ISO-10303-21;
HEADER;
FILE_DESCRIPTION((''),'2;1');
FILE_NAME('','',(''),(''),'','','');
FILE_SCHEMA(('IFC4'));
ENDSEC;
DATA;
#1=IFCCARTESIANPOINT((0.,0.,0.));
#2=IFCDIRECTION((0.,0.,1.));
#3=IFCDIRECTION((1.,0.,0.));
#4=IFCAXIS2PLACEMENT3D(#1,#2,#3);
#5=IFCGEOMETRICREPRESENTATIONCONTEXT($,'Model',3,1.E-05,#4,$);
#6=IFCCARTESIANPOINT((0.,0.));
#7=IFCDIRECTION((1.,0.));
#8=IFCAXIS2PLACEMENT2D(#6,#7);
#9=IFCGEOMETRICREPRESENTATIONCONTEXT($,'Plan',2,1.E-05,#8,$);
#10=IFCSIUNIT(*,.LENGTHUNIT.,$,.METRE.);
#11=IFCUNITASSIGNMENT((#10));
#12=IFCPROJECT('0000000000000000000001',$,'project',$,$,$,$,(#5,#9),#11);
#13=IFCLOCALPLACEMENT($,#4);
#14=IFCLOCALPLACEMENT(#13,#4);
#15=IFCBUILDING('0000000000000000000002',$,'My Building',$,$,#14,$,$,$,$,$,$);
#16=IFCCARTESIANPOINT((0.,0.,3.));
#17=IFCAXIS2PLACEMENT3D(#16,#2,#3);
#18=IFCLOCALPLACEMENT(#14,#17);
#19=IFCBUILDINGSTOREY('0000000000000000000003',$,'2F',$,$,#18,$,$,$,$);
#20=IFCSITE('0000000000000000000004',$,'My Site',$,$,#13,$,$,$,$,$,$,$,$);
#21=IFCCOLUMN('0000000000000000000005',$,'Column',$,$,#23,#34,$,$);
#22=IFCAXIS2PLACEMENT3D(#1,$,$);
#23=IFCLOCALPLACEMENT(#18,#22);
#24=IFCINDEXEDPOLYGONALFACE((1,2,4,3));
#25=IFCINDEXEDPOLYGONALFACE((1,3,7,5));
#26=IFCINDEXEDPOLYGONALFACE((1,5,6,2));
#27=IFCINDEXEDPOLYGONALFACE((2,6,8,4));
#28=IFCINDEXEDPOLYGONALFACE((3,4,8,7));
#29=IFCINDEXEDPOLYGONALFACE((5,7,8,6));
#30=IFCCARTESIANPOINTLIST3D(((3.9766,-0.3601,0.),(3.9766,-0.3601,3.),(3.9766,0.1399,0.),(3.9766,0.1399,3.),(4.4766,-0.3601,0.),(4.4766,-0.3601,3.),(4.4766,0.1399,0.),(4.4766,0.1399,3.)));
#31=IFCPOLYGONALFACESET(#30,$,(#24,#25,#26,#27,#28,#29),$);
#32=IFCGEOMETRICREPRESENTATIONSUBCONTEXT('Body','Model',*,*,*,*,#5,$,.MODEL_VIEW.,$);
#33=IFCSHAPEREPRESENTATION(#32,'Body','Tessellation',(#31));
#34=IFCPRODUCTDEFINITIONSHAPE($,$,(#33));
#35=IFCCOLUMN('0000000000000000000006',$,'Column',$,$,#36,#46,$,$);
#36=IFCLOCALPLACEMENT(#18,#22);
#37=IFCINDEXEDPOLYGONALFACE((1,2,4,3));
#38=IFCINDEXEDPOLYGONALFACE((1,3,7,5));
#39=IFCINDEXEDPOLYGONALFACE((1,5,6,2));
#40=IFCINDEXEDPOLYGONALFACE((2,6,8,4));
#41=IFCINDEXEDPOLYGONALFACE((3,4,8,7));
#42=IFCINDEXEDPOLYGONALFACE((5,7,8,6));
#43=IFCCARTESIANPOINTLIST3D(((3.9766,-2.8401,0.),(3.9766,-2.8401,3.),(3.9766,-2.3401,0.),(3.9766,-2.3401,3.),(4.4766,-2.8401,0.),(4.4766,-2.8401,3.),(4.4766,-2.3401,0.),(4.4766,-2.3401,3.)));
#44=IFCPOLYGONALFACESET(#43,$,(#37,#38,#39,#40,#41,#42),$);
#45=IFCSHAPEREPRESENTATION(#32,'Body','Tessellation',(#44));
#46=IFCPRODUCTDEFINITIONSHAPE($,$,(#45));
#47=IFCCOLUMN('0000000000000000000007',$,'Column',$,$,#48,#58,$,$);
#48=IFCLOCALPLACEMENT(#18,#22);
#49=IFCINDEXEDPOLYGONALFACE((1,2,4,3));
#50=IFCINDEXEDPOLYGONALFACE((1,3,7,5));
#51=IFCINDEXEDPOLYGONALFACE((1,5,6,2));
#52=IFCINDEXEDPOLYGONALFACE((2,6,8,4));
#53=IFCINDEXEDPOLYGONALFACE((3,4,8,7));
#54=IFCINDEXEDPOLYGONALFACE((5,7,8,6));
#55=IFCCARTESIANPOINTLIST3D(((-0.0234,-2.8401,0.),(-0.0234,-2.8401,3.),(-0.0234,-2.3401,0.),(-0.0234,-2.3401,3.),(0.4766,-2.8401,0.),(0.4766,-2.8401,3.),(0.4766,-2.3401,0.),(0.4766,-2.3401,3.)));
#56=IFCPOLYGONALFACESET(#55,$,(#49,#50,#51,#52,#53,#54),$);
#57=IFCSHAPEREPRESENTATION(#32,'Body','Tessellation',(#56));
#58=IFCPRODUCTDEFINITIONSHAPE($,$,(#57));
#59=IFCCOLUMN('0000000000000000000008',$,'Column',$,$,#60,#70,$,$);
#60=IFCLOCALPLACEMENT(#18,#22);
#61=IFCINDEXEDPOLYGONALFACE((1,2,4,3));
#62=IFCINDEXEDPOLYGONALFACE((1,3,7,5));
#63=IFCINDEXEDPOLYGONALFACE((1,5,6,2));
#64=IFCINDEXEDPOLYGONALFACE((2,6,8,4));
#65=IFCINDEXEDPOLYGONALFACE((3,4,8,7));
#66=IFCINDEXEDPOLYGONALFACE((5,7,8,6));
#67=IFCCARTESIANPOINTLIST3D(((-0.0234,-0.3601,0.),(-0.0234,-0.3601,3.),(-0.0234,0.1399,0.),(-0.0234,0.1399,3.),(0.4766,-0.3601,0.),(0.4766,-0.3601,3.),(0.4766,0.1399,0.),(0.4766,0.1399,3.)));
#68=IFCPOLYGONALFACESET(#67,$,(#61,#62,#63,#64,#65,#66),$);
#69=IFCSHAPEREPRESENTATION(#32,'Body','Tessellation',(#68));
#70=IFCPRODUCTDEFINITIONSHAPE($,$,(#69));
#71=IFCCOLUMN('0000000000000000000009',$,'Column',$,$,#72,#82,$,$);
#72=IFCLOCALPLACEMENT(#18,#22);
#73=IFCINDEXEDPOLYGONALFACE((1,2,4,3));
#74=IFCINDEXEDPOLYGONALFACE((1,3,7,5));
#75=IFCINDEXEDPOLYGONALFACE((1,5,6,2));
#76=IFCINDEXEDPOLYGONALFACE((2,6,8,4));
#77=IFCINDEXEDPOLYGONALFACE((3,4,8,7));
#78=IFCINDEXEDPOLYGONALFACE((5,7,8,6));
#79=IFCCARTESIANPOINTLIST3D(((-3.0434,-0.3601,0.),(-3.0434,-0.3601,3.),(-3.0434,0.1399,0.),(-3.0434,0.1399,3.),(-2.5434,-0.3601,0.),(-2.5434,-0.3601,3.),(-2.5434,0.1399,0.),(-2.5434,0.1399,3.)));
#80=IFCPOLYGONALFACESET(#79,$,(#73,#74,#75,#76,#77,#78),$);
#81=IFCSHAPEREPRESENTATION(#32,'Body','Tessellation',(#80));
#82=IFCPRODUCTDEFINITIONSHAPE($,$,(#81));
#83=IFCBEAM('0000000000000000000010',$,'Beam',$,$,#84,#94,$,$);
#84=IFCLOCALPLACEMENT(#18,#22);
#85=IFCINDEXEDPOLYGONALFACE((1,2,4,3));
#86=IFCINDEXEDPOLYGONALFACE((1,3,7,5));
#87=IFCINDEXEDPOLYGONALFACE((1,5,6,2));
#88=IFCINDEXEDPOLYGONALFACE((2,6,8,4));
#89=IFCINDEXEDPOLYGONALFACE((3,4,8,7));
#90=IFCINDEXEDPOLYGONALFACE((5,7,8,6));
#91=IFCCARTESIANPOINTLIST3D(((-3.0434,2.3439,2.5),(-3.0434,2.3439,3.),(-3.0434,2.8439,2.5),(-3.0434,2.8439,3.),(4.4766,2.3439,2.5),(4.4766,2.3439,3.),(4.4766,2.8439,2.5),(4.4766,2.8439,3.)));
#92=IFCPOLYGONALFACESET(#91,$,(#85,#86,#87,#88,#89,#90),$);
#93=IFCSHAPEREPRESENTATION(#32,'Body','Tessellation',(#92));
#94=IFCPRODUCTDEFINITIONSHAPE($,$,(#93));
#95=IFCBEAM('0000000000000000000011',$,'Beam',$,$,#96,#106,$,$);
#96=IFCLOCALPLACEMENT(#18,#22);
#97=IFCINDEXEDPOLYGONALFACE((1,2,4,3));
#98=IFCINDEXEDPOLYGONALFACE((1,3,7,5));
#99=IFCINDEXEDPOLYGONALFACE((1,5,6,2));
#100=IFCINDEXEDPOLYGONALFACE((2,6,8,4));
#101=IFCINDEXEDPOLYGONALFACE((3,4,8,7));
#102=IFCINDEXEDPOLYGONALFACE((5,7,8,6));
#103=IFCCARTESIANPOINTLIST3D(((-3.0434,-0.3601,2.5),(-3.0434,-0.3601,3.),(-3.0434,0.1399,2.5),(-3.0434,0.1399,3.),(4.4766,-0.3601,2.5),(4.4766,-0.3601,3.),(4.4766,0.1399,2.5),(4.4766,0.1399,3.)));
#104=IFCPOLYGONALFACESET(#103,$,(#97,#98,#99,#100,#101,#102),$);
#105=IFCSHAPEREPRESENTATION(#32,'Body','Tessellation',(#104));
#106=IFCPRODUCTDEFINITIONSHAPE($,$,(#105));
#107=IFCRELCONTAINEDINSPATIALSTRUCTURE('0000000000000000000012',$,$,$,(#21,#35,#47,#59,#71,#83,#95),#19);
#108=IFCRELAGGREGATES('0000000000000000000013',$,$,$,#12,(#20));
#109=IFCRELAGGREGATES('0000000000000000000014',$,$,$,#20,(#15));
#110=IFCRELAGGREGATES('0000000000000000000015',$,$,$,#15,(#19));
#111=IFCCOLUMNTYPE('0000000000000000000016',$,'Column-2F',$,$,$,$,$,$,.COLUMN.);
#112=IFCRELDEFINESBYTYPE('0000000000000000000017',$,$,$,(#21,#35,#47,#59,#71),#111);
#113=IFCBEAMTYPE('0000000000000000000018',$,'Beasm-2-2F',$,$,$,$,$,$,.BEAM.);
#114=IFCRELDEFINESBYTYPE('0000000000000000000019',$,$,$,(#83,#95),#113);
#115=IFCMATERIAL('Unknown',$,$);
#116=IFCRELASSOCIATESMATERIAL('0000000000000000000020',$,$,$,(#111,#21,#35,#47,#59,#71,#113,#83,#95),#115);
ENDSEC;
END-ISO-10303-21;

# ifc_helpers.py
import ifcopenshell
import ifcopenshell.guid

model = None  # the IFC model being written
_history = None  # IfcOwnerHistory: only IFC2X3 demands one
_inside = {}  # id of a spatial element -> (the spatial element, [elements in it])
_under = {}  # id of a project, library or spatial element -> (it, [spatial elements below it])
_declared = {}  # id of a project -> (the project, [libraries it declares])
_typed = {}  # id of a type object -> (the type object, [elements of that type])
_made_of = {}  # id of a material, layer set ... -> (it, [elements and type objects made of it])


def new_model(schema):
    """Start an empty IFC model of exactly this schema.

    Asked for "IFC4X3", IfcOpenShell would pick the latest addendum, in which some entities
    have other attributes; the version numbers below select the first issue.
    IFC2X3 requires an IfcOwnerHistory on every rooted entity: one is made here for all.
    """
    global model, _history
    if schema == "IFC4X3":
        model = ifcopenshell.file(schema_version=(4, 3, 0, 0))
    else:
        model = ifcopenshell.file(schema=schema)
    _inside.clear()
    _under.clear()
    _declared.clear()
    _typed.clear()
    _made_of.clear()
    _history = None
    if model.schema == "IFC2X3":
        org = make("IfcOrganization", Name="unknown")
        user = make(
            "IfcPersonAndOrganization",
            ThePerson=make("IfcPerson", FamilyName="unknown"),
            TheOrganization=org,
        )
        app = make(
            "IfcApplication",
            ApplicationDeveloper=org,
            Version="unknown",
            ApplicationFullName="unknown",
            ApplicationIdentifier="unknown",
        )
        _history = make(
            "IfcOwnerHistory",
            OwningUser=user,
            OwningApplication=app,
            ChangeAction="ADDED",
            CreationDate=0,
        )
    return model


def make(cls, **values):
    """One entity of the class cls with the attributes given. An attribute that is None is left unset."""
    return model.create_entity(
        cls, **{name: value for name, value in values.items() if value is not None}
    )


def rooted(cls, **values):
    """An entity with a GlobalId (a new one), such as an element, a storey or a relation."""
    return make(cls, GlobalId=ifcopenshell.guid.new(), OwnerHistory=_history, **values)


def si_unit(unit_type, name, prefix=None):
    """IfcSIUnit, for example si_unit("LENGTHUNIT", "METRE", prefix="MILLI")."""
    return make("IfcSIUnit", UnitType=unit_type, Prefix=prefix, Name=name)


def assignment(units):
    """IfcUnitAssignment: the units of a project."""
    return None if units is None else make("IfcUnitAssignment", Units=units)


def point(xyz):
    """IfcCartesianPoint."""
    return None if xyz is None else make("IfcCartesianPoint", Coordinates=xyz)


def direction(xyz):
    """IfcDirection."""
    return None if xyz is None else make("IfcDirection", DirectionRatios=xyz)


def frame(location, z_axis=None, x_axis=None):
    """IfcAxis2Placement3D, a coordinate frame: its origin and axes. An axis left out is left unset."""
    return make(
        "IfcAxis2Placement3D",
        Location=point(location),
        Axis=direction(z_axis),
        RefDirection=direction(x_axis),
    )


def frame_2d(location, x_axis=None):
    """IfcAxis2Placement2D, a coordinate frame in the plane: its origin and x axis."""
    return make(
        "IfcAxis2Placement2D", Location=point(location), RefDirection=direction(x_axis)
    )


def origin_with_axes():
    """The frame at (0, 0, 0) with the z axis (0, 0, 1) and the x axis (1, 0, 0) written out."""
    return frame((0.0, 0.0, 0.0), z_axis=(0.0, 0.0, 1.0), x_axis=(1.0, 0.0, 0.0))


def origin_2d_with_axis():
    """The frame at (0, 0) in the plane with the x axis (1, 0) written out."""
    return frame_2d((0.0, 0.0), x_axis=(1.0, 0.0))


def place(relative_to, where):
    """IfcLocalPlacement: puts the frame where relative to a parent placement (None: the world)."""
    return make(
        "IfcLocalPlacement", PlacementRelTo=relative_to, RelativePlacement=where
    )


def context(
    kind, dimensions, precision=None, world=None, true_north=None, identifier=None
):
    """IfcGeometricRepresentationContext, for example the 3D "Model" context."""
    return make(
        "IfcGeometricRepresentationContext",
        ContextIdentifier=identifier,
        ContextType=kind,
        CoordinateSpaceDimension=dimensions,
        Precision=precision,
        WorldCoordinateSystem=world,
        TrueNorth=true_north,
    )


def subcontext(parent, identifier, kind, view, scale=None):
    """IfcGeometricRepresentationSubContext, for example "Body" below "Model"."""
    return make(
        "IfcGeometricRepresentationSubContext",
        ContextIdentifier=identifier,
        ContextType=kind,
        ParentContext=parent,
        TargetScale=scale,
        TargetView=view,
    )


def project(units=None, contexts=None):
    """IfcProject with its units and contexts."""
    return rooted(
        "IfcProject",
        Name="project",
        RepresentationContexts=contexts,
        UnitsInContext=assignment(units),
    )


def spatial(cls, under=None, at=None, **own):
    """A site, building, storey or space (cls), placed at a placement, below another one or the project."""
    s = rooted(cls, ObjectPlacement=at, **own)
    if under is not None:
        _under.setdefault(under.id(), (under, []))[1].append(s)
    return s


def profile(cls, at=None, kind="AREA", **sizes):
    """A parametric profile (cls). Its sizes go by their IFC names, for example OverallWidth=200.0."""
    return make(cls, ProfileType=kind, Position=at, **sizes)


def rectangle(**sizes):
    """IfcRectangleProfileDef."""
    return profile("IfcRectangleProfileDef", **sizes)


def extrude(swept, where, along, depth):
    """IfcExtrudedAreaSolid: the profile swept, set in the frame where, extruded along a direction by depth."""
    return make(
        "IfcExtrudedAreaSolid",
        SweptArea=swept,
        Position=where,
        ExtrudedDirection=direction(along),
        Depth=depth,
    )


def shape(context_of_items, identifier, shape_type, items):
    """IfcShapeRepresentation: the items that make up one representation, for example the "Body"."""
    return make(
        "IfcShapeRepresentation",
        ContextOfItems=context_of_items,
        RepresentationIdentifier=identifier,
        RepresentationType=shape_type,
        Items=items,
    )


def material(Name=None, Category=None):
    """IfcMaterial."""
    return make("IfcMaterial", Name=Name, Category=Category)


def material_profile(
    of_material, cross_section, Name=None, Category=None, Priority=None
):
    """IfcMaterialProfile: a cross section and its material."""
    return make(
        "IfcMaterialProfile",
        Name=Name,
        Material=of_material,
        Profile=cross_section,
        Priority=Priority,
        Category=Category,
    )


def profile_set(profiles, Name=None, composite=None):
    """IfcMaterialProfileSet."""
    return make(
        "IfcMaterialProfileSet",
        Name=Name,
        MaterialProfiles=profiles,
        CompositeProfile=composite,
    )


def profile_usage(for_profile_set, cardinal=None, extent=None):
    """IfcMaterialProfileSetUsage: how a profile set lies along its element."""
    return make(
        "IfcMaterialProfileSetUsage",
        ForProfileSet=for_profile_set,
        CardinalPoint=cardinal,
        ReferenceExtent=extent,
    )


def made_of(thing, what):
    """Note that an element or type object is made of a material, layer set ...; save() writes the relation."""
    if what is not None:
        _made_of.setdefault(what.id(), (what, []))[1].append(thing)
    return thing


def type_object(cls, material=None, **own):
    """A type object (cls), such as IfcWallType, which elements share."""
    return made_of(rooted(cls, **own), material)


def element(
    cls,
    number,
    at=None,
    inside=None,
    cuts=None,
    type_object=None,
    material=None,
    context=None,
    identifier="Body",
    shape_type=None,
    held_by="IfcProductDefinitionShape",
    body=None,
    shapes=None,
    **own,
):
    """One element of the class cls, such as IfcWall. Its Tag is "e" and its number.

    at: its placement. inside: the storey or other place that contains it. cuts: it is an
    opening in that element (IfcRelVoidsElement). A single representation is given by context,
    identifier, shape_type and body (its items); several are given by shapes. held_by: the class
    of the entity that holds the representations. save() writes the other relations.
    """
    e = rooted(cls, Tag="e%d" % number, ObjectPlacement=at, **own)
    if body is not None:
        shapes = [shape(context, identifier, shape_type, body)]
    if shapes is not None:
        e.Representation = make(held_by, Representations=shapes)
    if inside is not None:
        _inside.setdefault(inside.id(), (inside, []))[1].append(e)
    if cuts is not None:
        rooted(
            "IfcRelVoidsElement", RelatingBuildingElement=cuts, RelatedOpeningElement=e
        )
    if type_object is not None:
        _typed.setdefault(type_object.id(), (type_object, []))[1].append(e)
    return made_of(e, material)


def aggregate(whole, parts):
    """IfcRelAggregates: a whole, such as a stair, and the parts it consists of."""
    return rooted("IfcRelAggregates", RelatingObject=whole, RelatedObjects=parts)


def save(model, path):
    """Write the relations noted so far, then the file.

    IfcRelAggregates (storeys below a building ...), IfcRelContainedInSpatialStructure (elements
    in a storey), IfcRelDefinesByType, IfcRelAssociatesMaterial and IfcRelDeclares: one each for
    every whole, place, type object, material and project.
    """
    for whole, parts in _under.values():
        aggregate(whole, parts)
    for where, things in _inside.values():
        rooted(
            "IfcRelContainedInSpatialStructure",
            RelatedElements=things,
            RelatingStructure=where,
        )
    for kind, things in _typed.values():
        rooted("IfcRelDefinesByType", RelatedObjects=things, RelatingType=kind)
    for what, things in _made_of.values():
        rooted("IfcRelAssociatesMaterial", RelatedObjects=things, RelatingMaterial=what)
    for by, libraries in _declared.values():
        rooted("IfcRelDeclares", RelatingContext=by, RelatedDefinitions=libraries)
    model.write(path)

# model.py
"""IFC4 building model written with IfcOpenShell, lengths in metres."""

from ifc_helpers import new_model, si_unit, frame, origin_with_axes, origin_2d_with_axis, place, context, subcontext, project, spatial, rectangle, extrude, material, material_profile, profile_set, profile_usage, type_object, element, save


model = new_model("IFC4")

# Units and contexts
model_context = context("Model", 3, precision=1e-05, world=origin_with_axes())
plan_context = context("Plan", 2, precision=1e-05, world=origin_2d_with_axis())
body_context_1 = subcontext(model_context, "Body", "Model", "MODEL_VIEW")
ifc_project = project(units=[si_unit("LENGTHUNIT", "METRE")], contexts=[model_context, plan_context])

# Site, building, storey
site_placement = place(None, origin_with_axes())
site = spatial("IfcSite", under=ifc_project, at=site_placement, Name="My Site")
building_placement = place(site_placement, origin_with_axes())
building = spatial("IfcBuilding", under=site, at=building_placement, Name="My Building")
storey_placement = place(building_placement, frame((0.0, 0.0, 3.0), z_axis=(0.0, 0.0, 1.0), x_axis=(1.0, 0.0, 0.0)))
storey = spatial("IfcBuildingStorey", under=building, at=storey_placement, Name="2F")

# Columns
ifc_material = material(Name="Unknown")
ifc_material_profile_1 = material_profile(ifc_material, rectangle(XDim=0.5, YDim=0.5))
ifc_profile_set_1 = profile_set([ifc_material_profile_1])
ifc_profile_usage_1 = profile_usage(ifc_profile_set_1, cardinal=7)
column_type = type_object("IfcColumnType", Name="Column-2F", PredefinedType="COLUMN", material=ifc_profile_set_1)
column_1_placement = place(storey_placement, frame((4.4766, 0.1399, 0.0), z_axis=(0.0, 0.0, 1.0), x_axis=(1.0, 0.0, 0.0)))
element("IfcColumn", 1, at=column_1_placement, inside=storey, type_object=column_type, material=ifc_profile_usage_1, Name="Column", context=body_context_1, shape_type="SweptSolid", body=[
    extrude(rectangle(XDim=0.5, YDim=0.5), frame((-0.25, -0.25, 0.0), z_axis=(0.0, 0.0, 1.0), x_axis=(1.0, 0.0, 0.0)), (0.0, 0.0, 1.0), 3.0),
])
ifc_profile_usage_2 = profile_usage(ifc_profile_set_1, cardinal=7)
column_2_placement = place(storey_placement, frame((4.4766, -2.3401, 0.0), z_axis=(0.0, 0.0, 1.0), x_axis=(1.0, 0.0, 0.0)))
element("IfcColumn", 2, at=column_2_placement, inside=storey, type_object=column_type, material=ifc_profile_usage_2, Name="Column", context=body_context_1, shape_type="SweptSolid", body=[
    extrude(rectangle(XDim=0.5, YDim=0.5), frame((-0.25, -0.25, 0.0), z_axis=(0.0, 0.0, 1.0), x_axis=(1.0, 0.0, 0.0)), (0.0, 0.0, 1.0), 3.0),
])
ifc_profile_usage_3 = profile_usage(ifc_profile_set_1, cardinal=7)
column_3_placement = place(storey_placement, frame((0.4766, -2.3401, 0.0), z_axis=(0.0, 0.0, 1.0), x_axis=(1.0, 0.0, 0.0)))
element("IfcColumn", 3, at=column_3_placement, inside=storey, type_object=column_type, material=ifc_profile_usage_3, Name="Column", context=body_context_1, shape_type="SweptSolid", body=[
    extrude(rectangle(XDim=0.5, YDim=0.5), frame((-0.25, -0.25, 0.0), z_axis=(0.0, 0.0, 1.0), x_axis=(1.0, 0.0, 0.0)), (0.0, 0.0, 1.0), 3.0),
])
ifc_profile_usage_4 = profile_usage(ifc_profile_set_1, cardinal=7)
column_4_placement = place(storey_placement, frame((0.4766, 0.1399, 0.0), z_axis=(0.0, 0.0, 1.0), x_axis=(1.0, 0.0, 0.0)))
element("IfcColumn", 4, at=column_4_placement, inside=storey, type_object=column_type, material=ifc_profile_usage_4, Name="Column", context=body_context_1, shape_type="SweptSolid", body=[
    extrude(rectangle(XDim=0.5, YDim=0.5), frame((-0.25, -0.25, 0.0), z_axis=(0.0, 0.0, 1.0), x_axis=(1.0, 0.0, 0.0)), (0.0, 0.0, 1.0), 3.0),
])
ifc_profile_usage_5 = profile_usage(ifc_profile_set_1, cardinal=7)
column_5_placement = place(storey_placement, frame((-2.5434, 0.1399, 0.0), z_axis=(0.0, 0.0, 1.0), x_axis=(1.0, 0.0, 0.0)))
element("IfcColumn", 5, at=column_5_placement, inside=storey, type_object=column_type, material=ifc_profile_usage_5, Name="Column", context=body_context_1, shape_type="SweptSolid", body=[
    extrude(rectangle(XDim=0.5, YDim=0.5), frame((-0.25, -0.25, 0.0), z_axis=(0.0, 0.0, 1.0), x_axis=(1.0, 0.0, 0.0)), (0.0, 0.0, 1.0), 3.0),
])

# Beams
ifc_material_profile_2 = material_profile(ifc_material, rectangle(XDim=0.5, YDim=0.5))
ifc_profile_set_2 = profile_set([ifc_material_profile_2])
ifc_profile_usage_6 = profile_usage(ifc_profile_set_2, cardinal=7)
beam_type = type_object("IfcBeamType", Name="Beasm-2-2F", PredefinedType="BEAM", material=ifc_profile_set_2)
beam_1_placement = place(storey_placement, frame((4.4766, 2.3439, 3.0), z_axis=(-1.0, 0.0, 0.0), x_axis=(0.0, -1.0, 0.0)))
element("IfcBeam", 6, at=beam_1_placement, inside=storey, type_object=beam_type, material=ifc_profile_usage_6, Name="Beam", context=body_context_1, shape_type="SweptSolid", body=[
    extrude(rectangle(XDim=0.5, YDim=0.5), frame((-0.25, -0.25, 0.0), z_axis=(0.0, 0.0, 1.0), x_axis=(1.0, 0.0, 0.0)), (0.0, 0.0, 1.0), 7.52),
])
ifc_profile_usage_7 = profile_usage(ifc_profile_set_2, cardinal=7)
beam_2_placement = place(storey_placement, frame((4.4766, -0.3601, 3.0), z_axis=(-1.0, 0.0, 0.0), x_axis=(0.0, -1.0, 0.0)))
element("IfcBeam", 7, at=beam_2_placement, inside=storey, type_object=beam_type, material=ifc_profile_usage_7, Name="Beam", context=body_context_1, shape_type="SweptSolid", body=[
    extrude(rectangle(XDim=0.5, YDim=0.5), frame((-0.25, -0.25, 0.0), z_axis=(0.0, 0.0, 1.0), x_axis=(1.0, 0.0, 0.0)), (0.0, 0.0, 1.0), 7.52),
])

save(model, "model.ifc")
